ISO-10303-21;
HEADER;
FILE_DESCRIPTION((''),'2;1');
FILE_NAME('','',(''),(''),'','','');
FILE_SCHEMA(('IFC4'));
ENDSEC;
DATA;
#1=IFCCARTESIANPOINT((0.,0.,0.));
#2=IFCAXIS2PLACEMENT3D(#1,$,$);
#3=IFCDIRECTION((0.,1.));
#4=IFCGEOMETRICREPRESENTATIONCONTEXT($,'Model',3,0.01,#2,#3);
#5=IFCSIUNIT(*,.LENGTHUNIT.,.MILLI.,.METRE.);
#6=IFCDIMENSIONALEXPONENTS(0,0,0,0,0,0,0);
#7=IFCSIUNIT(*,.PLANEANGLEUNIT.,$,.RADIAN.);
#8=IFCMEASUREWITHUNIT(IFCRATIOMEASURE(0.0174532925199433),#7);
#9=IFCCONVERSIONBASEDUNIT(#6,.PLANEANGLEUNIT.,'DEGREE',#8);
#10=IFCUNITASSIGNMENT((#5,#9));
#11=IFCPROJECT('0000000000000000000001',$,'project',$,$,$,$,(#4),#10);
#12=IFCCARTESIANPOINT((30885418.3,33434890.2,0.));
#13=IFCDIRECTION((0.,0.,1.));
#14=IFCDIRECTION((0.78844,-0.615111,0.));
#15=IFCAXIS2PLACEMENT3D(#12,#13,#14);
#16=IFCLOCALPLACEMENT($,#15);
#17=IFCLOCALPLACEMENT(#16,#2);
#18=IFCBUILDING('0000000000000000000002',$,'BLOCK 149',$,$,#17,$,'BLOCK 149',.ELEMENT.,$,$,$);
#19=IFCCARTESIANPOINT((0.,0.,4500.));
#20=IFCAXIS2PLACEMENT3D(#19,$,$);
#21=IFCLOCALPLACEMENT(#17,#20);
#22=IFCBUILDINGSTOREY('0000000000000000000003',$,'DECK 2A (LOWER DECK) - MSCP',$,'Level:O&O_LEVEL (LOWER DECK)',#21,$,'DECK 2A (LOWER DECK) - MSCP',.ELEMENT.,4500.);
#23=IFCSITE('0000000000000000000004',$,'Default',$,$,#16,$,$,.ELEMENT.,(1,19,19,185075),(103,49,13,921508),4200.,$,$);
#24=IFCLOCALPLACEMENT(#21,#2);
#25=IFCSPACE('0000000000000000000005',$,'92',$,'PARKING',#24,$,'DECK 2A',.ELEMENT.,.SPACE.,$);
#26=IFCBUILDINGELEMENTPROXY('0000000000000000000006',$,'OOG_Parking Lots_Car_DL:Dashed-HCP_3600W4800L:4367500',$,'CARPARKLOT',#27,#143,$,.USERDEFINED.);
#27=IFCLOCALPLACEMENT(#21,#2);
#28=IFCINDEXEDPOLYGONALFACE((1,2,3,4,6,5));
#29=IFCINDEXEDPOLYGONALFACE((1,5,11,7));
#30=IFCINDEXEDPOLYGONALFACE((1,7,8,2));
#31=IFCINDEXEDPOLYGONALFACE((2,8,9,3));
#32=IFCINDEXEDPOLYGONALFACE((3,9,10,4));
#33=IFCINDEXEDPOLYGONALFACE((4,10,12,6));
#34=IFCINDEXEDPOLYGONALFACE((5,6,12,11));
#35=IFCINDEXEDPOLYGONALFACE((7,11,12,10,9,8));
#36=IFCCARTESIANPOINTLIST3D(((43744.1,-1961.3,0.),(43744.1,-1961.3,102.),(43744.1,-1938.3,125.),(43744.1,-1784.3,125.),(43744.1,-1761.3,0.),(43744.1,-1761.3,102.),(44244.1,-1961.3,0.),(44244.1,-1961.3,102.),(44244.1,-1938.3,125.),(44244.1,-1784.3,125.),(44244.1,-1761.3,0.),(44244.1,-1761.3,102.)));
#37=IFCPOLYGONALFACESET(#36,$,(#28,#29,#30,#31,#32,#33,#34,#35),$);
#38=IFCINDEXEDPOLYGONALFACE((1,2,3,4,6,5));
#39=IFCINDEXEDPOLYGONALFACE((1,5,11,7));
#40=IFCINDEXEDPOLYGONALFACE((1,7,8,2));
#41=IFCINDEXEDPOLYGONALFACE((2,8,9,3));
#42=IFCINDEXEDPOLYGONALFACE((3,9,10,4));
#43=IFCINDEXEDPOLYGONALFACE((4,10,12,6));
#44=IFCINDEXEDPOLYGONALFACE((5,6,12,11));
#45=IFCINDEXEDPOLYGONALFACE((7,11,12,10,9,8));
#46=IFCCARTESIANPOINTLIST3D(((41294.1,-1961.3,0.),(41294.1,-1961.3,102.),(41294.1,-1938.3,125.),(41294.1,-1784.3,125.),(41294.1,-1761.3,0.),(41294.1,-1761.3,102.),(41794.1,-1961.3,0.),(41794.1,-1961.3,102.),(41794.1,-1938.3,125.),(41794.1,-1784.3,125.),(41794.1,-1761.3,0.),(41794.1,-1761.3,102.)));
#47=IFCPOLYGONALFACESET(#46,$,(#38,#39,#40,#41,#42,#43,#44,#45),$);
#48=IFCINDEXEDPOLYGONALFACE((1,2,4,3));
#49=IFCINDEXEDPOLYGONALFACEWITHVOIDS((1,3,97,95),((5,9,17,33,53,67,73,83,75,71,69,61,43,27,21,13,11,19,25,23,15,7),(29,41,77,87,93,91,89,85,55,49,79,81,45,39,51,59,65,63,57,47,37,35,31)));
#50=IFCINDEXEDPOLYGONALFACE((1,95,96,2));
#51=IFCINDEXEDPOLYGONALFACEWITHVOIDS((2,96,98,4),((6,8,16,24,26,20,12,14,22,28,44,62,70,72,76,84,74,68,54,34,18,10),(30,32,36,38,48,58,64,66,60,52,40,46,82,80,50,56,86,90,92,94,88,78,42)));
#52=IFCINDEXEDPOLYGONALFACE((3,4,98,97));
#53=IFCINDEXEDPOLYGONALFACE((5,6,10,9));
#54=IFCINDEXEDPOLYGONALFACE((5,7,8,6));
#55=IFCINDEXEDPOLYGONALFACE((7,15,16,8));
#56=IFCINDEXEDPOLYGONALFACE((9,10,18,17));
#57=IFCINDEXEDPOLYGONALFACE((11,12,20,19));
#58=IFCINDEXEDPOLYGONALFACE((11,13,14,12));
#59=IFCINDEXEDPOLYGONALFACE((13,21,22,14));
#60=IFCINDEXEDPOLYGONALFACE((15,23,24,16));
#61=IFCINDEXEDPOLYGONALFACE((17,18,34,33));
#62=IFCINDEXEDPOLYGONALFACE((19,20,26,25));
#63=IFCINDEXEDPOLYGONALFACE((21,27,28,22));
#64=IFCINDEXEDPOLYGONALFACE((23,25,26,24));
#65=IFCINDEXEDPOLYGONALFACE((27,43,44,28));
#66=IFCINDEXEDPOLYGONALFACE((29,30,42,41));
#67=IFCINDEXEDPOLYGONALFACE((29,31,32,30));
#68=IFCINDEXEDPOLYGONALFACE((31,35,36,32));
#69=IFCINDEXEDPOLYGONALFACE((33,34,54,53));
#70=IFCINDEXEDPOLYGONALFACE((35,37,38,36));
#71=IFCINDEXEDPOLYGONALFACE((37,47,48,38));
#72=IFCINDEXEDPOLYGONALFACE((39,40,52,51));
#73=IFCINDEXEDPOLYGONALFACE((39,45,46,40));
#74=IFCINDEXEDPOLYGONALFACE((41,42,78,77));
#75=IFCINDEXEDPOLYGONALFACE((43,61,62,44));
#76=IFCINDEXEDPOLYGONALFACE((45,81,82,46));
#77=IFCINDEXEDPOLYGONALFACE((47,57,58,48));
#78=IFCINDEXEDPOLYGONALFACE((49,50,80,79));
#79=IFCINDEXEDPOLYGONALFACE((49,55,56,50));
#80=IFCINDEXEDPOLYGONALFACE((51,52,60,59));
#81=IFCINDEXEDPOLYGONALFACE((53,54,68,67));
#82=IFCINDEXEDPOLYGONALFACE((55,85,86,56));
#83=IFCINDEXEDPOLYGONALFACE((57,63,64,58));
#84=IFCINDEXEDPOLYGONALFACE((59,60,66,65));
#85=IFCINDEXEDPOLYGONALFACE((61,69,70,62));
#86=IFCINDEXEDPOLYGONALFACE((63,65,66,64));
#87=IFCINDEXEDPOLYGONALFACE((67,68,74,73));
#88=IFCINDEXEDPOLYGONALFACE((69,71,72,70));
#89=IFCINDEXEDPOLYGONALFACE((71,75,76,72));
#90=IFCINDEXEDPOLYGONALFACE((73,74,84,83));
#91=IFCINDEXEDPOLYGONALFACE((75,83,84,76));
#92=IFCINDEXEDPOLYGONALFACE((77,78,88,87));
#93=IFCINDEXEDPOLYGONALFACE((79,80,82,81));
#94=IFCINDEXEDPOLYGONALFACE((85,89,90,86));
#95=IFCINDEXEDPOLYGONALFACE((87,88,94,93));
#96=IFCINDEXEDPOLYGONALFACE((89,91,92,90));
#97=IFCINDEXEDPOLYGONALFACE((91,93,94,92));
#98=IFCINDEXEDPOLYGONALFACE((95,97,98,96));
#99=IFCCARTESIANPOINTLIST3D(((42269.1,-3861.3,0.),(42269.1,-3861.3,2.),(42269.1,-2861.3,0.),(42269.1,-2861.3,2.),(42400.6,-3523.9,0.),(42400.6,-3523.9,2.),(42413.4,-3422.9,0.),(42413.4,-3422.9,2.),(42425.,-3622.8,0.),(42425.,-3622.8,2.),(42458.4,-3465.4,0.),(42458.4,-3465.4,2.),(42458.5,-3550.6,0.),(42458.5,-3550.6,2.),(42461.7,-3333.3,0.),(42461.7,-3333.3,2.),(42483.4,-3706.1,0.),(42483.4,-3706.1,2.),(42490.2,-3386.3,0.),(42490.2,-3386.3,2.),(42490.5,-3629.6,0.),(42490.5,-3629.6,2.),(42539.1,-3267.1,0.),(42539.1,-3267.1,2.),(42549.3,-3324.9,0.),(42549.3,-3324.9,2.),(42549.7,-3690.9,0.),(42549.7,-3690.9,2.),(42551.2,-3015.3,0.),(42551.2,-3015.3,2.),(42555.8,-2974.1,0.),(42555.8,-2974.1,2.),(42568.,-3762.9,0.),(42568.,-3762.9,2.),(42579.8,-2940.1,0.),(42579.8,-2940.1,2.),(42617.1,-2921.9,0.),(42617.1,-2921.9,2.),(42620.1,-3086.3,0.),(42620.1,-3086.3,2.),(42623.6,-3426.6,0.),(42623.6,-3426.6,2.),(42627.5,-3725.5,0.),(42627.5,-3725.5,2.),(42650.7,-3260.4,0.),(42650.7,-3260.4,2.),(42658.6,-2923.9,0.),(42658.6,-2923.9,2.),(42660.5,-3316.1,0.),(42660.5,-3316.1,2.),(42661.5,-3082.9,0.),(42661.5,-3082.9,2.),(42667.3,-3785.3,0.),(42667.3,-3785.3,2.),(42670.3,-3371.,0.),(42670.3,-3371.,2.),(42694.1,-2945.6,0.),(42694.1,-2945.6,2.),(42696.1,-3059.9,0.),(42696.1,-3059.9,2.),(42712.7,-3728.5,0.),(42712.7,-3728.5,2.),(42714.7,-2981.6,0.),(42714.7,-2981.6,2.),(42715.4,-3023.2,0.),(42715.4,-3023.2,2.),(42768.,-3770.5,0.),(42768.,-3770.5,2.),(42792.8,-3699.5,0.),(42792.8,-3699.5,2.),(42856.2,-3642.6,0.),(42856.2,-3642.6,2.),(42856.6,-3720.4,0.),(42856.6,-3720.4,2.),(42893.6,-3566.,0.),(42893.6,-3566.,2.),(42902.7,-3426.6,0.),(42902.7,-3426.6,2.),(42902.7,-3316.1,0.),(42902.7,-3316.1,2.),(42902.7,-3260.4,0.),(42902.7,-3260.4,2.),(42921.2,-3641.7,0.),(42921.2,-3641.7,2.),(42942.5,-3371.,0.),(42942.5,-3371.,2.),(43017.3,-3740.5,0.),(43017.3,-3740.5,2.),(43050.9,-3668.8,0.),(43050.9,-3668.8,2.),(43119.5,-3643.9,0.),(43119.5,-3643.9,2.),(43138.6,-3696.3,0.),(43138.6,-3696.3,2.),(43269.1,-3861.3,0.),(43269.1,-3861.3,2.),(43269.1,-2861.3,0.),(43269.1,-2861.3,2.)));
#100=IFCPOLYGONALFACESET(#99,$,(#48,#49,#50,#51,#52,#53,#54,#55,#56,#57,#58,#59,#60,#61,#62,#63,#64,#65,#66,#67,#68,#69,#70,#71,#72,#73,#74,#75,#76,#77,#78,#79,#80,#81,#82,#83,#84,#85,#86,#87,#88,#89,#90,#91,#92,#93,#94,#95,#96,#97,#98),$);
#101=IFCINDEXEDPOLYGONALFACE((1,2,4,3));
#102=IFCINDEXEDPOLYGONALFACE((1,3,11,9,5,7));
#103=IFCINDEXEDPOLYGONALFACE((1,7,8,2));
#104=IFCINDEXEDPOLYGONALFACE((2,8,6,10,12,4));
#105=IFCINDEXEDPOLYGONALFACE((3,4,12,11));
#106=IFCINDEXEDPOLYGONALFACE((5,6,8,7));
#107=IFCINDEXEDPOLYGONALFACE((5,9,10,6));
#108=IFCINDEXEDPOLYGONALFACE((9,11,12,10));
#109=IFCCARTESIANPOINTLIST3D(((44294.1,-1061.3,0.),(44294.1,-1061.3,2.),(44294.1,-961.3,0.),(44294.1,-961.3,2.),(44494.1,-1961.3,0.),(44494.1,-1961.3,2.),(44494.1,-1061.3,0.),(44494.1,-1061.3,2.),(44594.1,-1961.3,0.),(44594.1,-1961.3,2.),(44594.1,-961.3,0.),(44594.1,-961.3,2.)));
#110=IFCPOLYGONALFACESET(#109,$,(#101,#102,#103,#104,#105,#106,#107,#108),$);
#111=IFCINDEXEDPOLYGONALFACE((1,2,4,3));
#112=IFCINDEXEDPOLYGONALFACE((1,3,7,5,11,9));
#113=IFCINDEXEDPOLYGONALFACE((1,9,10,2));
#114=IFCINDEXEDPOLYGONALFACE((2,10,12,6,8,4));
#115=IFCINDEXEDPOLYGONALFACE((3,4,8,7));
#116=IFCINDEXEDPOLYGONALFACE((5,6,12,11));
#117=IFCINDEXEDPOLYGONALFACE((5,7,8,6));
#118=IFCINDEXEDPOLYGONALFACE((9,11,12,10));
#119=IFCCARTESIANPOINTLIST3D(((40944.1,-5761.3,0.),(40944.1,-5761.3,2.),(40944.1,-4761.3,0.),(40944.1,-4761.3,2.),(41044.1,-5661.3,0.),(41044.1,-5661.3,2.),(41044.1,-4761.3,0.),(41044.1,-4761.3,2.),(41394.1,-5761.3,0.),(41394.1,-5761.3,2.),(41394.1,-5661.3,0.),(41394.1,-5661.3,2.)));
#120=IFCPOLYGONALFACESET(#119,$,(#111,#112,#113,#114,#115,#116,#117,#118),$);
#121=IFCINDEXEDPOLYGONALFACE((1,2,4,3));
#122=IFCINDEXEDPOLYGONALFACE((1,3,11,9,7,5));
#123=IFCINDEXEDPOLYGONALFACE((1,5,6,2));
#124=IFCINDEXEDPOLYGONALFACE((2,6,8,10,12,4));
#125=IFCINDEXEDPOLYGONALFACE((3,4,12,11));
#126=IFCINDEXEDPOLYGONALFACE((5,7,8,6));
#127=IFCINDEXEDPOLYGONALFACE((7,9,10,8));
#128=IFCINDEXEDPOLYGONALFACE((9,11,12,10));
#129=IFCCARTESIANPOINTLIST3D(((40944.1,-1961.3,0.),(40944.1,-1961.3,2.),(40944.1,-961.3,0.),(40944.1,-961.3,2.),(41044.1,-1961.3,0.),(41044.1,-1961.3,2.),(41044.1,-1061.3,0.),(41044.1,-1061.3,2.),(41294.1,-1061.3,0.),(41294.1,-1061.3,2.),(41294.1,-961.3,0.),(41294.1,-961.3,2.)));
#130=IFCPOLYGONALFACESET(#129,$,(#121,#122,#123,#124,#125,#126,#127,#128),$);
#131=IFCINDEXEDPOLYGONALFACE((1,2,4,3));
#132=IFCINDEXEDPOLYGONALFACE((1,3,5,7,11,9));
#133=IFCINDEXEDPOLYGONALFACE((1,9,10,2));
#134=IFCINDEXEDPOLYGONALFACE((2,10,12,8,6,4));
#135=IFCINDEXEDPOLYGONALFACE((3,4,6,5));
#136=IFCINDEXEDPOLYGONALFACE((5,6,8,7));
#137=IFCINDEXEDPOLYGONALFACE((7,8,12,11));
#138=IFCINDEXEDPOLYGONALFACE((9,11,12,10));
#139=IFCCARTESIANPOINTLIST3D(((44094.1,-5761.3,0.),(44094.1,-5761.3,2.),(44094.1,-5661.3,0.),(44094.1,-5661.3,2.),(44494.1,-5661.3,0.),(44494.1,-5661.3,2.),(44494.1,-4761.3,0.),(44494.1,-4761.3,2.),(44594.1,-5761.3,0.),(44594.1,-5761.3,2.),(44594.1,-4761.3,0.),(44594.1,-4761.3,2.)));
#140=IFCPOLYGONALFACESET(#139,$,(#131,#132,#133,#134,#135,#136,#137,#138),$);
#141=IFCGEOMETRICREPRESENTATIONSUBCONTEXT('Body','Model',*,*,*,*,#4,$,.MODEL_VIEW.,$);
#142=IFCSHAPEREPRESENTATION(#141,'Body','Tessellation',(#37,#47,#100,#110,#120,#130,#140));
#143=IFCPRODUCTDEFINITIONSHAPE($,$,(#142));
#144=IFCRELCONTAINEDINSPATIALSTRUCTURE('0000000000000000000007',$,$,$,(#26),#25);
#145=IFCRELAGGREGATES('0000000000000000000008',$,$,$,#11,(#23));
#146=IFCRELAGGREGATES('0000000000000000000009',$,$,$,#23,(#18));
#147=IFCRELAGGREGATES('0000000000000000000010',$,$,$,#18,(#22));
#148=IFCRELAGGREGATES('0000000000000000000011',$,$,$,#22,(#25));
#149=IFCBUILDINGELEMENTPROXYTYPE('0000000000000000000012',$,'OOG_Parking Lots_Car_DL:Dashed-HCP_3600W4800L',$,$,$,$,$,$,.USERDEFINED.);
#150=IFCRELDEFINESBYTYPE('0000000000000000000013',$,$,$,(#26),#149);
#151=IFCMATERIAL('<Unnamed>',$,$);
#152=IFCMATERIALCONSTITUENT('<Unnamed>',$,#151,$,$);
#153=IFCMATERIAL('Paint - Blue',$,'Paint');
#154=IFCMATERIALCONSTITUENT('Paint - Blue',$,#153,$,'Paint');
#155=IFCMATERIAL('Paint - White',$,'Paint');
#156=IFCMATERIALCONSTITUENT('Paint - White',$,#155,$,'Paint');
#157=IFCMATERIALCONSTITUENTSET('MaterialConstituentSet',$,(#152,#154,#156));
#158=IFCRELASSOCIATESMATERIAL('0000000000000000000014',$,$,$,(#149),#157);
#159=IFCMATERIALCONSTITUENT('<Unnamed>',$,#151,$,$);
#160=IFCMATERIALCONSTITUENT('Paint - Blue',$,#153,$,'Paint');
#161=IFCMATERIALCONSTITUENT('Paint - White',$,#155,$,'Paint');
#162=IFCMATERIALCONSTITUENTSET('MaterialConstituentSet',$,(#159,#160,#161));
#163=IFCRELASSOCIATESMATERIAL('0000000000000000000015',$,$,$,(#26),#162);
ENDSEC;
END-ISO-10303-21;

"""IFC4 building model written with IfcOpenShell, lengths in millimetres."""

from ifc_helpers import new_model, entity, si_unit, converted_unit, direction, frame, origin, place, context, subcontext, project, spatial, indexed_curve, outline, extrude, source, transform, mapped, material, constituent, constituent_set, type_object, type_shapes, element, save


model = new_model("IFC4")

# Units and contexts
model_context = context("Model", 3, precision=0.01, world=origin(), true_north=direction((0.0, 1.0)))
body_context = subcontext(model_context, "Body", "Model", "MODEL_VIEW")
ifc_project = project(units=[si_unit("LENGTHUNIT", "METRE", prefix="MILLI"), converted_unit("PLANEANGLEUNIT", "DEGREE", entity("IfcRatioMeasure", 0.0174532925199433), si_unit("PLANEANGLEUNIT", "RADIAN"), dimensions=[0, 0, 0, 0, 0, 0, 0])], contexts=[model_context])

# Site, building, storey
site_placement = place(None, frame((30885418.3, 33434890.2, 0.0), z_axis=(0.0, 0.0, 1.0), x_axis=(0.78844, -0.615111, 0.0)))
site = spatial("IfcSite", under=ifc_project, at=site_placement, Name="Default", CompositionType="ELEMENT", RefLatitude=(1, 19, 19, 185075), RefLongitude=(103, 49, 13, 921508), RefElevation=4200.0)
building_placement = place(site_placement, origin())
building = spatial("IfcBuilding", under=site, at=building_placement, Name="BLOCK 149", LongName="BLOCK 149", CompositionType="ELEMENT")
storey_placement = place(building_placement, frame((0.0, 0.0, 4500.0)))
storey = spatial("IfcBuildingStorey", under=building, at=storey_placement, Name="DECK 2A (LOWER DECK) - MSCP", ObjectType="Level:O&O_LEVEL (LOWER DECK)", LongName="DECK 2A (LOWER DECK) - MSCP", CompositionType="ELEMENT", Elevation=4500.0)

# Shared definitions
ifc_material_1 = material(Name="<Unnamed>")

# Shared definitions
space_placement = place(storey_placement, origin())
space = spatial("IfcSpace", under=storey, at=space_placement, Name="92", ObjectType="PARKING", LongName="DECK 2A", CompositionType="ELEMENT", PredefinedType="SPACE")

# Building element proxy
ifc_material_2 = material(Name="Paint - White", Category="Paint")
ifc_constituent_1 = constituent(ifc_material_1, Name="<Unnamed>")
ifc_material_3 = material(Name="Paint - Blue", Category="Paint")
ifc_constituent_2 = constituent(ifc_material_3, Name="Paint - Blue", Category="Paint")
ifc_constituent_3 = constituent(ifc_material_2, Name="Paint - White", Category="Paint")
ifc_constituent_set_1 = constituent_set(constituents=[ifc_constituent_1, ifc_constituent_2, ifc_constituent_3], Name="MaterialConstituentSet")
ifc_constituent_4 = constituent(ifc_material_1, Name="<Unnamed>")
ifc_constituent_5 = constituent(ifc_material_3, Name="Paint - Blue", Category="Paint")
ifc_constituent_6 = constituent(ifc_material_2, Name="Paint - White", Category="Paint")
ifc_constituent_set_2 = constituent_set(constituents=[ifc_constituent_4, ifc_constituent_5, ifc_constituent_6], Name="MaterialConstituentSet")
building_element_proxy_type_1 = type_object("IfcBuildingElementProxyType", Name="OOG_Parking Lots_Car_DL:Dashed-HCP_3600W4800L", PredefinedType="USERDEFINED", material=ifc_constituent_set_2)
shared_shape_1 = source(origin(), body_context, "Body", "SweptSolid", [
    extrude(outline(indexed_curve([(-100.0, -75.7), (100.0, -75.7), (100.0, 26.3), (77.0, 49.3), (-77.0, 49.3), (-100.0, 26.3), (-100.0, -75.7)], self_intersect=False)), frame((2750.0, -850.0, 75.7), z_axis=(1.0, 0.0, 0.0), x_axis=(0.0, 1.0, 0.0)), (0.0, 0.0, 1.0), 500.0),
    extrude(outline(indexed_curve([(-100.0, -75.7), (100.0, -75.7), (100.0, 26.3), (77.0, 49.3), (-77.0, 49.3), (-100.0, 26.3), (-100.0, -75.7)], self_intersect=False)), frame((300.0, -850.0, 75.7), z_axis=(1.0, 0.0, 0.0), x_axis=(0.0, 1.0, 0.0)), (0.0, 0.0, 1.0), 500.0),
    extrude(outline(indexed_curve([(-500.0, -500.0), (500.0, -500.0), (500.0, 500.0), (-500.0, 500.0), (-500.0, -500.0)], self_intersect=False), holes=[indexed_curve([(149.0, -274.9), (118.4, -100.9), (-133.6, -100.9), (-133.6, -45.2), (108.6, -45.2), (98.8, 9.7), (-173.4, 9.7), (-281.8, 307.5), (-350.4, 282.6), (-369.5, 335.1), (-248.2, 379.2), (-133.6, 65.3), (145.5, 65.3), (218.0, -346.0), (213.3, -387.2), (189.3, -421.2), (152.0, -439.4), (110.5, -437.4), (75.1, -415.7), (54.4, -379.7), (53.7, -338.1), (73.0, -301.3), (107.6, -278.4), (149.0, -274.9)], self_intersect=False), indexed_curve([(-124.5, 204.7), (-152.1, 280.4), (-87.5, 359.1), (1.1, 409.2), (101.8, 424.0), (201.1, 401.6), (285.7, 344.9), (344.1, 261.5), (368.6, 162.6), (355.8, 61.6), (307.4, -28.0), (230.0, -94.2), (219.8, -36.4), (278.9, 25.0), (310.7, 104.1), (310.6, 189.3), (278.7, 268.3), (219.4, 329.6), (141.6, 364.2), (56.5, 367.3), (-23.6, 338.2), (-87.0, 281.3), (-124.5, 204.7)], self_intersect=False)]), frame((1775.0, -2350.0, 0.0), z_axis=(0.0, 0.0, 1.0), x_axis=(-1.0, 0.0, 0.0)), (0.0, 0.0, 1.0), 2.0),
    extrude(outline(indexed_curve([(-633.3, -133.3), (366.7, -133.3), (366.7, 166.7), (266.7, 166.7), (266.7, -33.3), (-633.3, -33.3), (-633.3, -133.3)], self_intersect=False)), frame((3466.7, -316.7, 0.0), z_axis=(0.0, 0.0, 1.0), x_axis=(0.0, 1.0, 0.0)), (0.0, 0.0, 1.0), 2.0),
    extrude(outline(indexed_curve([(-633.3, -183.3), (366.7, -183.3), (366.7, 266.7), (266.7, 266.7), (266.7, -83.3), (-633.3, -83.3), (-633.3, -183.3)], self_intersect=False)), frame((133.3, -4383.3, 0.0), z_axis=(0.0, 0.0, 1.0), x_axis=(0.0, -1.0, 0.0)), (0.0, 0.0, 1.0), 2.0),
    extrude(outline(indexed_curve([(-200.0, -366.7), (150.0, -366.7), (150.0, 633.3), (50.0, 633.3), (50.0, -266.7), (-200.0, -266.7), (-200.0, -366.7)], self_intersect=False)), frame((100.0, -316.7, 0.0), z_axis=(0.0, 0.0, 1.0), x_axis=(-1.0, 0.0, 0.0)), (0.0, 0.0, 1.0), 2.0),
    extrude(outline(indexed_curve([(-300.0, -366.7), (200.0, -366.7), (200.0, 633.3), (100.0, 633.3), (100.0, -266.7), (-300.0, -266.7), (-300.0, -366.7)], self_intersect=False)), frame((3400.0, -4383.3, 0.0)), (0.0, 0.0, 1.0), 2.0),
])
type_shapes(building_element_proxy_type_1, [shared_shape_1])
proxy_1_placement = place(space_placement, frame((40994.1, -1011.3, 0.0)))
element("IfcBuildingElementProxy", 1, at=proxy_1_placement, inside=space, type_object=building_element_proxy_type_1, material=ifc_constituent_set_1, Name="OOG_Parking Lots_Car_DL:Dashed-HCP_3600W4800L:4367500", ObjectType="CARPARKLOT", PredefinedType="USERDEFINED", context=body_context, shape_type="MappedRepresentation", body=[
    mapped(shared_shape_1, transform((0.0, 0.0, 0.0), scale=1.0)),
])

save(model, "model.ifc")
